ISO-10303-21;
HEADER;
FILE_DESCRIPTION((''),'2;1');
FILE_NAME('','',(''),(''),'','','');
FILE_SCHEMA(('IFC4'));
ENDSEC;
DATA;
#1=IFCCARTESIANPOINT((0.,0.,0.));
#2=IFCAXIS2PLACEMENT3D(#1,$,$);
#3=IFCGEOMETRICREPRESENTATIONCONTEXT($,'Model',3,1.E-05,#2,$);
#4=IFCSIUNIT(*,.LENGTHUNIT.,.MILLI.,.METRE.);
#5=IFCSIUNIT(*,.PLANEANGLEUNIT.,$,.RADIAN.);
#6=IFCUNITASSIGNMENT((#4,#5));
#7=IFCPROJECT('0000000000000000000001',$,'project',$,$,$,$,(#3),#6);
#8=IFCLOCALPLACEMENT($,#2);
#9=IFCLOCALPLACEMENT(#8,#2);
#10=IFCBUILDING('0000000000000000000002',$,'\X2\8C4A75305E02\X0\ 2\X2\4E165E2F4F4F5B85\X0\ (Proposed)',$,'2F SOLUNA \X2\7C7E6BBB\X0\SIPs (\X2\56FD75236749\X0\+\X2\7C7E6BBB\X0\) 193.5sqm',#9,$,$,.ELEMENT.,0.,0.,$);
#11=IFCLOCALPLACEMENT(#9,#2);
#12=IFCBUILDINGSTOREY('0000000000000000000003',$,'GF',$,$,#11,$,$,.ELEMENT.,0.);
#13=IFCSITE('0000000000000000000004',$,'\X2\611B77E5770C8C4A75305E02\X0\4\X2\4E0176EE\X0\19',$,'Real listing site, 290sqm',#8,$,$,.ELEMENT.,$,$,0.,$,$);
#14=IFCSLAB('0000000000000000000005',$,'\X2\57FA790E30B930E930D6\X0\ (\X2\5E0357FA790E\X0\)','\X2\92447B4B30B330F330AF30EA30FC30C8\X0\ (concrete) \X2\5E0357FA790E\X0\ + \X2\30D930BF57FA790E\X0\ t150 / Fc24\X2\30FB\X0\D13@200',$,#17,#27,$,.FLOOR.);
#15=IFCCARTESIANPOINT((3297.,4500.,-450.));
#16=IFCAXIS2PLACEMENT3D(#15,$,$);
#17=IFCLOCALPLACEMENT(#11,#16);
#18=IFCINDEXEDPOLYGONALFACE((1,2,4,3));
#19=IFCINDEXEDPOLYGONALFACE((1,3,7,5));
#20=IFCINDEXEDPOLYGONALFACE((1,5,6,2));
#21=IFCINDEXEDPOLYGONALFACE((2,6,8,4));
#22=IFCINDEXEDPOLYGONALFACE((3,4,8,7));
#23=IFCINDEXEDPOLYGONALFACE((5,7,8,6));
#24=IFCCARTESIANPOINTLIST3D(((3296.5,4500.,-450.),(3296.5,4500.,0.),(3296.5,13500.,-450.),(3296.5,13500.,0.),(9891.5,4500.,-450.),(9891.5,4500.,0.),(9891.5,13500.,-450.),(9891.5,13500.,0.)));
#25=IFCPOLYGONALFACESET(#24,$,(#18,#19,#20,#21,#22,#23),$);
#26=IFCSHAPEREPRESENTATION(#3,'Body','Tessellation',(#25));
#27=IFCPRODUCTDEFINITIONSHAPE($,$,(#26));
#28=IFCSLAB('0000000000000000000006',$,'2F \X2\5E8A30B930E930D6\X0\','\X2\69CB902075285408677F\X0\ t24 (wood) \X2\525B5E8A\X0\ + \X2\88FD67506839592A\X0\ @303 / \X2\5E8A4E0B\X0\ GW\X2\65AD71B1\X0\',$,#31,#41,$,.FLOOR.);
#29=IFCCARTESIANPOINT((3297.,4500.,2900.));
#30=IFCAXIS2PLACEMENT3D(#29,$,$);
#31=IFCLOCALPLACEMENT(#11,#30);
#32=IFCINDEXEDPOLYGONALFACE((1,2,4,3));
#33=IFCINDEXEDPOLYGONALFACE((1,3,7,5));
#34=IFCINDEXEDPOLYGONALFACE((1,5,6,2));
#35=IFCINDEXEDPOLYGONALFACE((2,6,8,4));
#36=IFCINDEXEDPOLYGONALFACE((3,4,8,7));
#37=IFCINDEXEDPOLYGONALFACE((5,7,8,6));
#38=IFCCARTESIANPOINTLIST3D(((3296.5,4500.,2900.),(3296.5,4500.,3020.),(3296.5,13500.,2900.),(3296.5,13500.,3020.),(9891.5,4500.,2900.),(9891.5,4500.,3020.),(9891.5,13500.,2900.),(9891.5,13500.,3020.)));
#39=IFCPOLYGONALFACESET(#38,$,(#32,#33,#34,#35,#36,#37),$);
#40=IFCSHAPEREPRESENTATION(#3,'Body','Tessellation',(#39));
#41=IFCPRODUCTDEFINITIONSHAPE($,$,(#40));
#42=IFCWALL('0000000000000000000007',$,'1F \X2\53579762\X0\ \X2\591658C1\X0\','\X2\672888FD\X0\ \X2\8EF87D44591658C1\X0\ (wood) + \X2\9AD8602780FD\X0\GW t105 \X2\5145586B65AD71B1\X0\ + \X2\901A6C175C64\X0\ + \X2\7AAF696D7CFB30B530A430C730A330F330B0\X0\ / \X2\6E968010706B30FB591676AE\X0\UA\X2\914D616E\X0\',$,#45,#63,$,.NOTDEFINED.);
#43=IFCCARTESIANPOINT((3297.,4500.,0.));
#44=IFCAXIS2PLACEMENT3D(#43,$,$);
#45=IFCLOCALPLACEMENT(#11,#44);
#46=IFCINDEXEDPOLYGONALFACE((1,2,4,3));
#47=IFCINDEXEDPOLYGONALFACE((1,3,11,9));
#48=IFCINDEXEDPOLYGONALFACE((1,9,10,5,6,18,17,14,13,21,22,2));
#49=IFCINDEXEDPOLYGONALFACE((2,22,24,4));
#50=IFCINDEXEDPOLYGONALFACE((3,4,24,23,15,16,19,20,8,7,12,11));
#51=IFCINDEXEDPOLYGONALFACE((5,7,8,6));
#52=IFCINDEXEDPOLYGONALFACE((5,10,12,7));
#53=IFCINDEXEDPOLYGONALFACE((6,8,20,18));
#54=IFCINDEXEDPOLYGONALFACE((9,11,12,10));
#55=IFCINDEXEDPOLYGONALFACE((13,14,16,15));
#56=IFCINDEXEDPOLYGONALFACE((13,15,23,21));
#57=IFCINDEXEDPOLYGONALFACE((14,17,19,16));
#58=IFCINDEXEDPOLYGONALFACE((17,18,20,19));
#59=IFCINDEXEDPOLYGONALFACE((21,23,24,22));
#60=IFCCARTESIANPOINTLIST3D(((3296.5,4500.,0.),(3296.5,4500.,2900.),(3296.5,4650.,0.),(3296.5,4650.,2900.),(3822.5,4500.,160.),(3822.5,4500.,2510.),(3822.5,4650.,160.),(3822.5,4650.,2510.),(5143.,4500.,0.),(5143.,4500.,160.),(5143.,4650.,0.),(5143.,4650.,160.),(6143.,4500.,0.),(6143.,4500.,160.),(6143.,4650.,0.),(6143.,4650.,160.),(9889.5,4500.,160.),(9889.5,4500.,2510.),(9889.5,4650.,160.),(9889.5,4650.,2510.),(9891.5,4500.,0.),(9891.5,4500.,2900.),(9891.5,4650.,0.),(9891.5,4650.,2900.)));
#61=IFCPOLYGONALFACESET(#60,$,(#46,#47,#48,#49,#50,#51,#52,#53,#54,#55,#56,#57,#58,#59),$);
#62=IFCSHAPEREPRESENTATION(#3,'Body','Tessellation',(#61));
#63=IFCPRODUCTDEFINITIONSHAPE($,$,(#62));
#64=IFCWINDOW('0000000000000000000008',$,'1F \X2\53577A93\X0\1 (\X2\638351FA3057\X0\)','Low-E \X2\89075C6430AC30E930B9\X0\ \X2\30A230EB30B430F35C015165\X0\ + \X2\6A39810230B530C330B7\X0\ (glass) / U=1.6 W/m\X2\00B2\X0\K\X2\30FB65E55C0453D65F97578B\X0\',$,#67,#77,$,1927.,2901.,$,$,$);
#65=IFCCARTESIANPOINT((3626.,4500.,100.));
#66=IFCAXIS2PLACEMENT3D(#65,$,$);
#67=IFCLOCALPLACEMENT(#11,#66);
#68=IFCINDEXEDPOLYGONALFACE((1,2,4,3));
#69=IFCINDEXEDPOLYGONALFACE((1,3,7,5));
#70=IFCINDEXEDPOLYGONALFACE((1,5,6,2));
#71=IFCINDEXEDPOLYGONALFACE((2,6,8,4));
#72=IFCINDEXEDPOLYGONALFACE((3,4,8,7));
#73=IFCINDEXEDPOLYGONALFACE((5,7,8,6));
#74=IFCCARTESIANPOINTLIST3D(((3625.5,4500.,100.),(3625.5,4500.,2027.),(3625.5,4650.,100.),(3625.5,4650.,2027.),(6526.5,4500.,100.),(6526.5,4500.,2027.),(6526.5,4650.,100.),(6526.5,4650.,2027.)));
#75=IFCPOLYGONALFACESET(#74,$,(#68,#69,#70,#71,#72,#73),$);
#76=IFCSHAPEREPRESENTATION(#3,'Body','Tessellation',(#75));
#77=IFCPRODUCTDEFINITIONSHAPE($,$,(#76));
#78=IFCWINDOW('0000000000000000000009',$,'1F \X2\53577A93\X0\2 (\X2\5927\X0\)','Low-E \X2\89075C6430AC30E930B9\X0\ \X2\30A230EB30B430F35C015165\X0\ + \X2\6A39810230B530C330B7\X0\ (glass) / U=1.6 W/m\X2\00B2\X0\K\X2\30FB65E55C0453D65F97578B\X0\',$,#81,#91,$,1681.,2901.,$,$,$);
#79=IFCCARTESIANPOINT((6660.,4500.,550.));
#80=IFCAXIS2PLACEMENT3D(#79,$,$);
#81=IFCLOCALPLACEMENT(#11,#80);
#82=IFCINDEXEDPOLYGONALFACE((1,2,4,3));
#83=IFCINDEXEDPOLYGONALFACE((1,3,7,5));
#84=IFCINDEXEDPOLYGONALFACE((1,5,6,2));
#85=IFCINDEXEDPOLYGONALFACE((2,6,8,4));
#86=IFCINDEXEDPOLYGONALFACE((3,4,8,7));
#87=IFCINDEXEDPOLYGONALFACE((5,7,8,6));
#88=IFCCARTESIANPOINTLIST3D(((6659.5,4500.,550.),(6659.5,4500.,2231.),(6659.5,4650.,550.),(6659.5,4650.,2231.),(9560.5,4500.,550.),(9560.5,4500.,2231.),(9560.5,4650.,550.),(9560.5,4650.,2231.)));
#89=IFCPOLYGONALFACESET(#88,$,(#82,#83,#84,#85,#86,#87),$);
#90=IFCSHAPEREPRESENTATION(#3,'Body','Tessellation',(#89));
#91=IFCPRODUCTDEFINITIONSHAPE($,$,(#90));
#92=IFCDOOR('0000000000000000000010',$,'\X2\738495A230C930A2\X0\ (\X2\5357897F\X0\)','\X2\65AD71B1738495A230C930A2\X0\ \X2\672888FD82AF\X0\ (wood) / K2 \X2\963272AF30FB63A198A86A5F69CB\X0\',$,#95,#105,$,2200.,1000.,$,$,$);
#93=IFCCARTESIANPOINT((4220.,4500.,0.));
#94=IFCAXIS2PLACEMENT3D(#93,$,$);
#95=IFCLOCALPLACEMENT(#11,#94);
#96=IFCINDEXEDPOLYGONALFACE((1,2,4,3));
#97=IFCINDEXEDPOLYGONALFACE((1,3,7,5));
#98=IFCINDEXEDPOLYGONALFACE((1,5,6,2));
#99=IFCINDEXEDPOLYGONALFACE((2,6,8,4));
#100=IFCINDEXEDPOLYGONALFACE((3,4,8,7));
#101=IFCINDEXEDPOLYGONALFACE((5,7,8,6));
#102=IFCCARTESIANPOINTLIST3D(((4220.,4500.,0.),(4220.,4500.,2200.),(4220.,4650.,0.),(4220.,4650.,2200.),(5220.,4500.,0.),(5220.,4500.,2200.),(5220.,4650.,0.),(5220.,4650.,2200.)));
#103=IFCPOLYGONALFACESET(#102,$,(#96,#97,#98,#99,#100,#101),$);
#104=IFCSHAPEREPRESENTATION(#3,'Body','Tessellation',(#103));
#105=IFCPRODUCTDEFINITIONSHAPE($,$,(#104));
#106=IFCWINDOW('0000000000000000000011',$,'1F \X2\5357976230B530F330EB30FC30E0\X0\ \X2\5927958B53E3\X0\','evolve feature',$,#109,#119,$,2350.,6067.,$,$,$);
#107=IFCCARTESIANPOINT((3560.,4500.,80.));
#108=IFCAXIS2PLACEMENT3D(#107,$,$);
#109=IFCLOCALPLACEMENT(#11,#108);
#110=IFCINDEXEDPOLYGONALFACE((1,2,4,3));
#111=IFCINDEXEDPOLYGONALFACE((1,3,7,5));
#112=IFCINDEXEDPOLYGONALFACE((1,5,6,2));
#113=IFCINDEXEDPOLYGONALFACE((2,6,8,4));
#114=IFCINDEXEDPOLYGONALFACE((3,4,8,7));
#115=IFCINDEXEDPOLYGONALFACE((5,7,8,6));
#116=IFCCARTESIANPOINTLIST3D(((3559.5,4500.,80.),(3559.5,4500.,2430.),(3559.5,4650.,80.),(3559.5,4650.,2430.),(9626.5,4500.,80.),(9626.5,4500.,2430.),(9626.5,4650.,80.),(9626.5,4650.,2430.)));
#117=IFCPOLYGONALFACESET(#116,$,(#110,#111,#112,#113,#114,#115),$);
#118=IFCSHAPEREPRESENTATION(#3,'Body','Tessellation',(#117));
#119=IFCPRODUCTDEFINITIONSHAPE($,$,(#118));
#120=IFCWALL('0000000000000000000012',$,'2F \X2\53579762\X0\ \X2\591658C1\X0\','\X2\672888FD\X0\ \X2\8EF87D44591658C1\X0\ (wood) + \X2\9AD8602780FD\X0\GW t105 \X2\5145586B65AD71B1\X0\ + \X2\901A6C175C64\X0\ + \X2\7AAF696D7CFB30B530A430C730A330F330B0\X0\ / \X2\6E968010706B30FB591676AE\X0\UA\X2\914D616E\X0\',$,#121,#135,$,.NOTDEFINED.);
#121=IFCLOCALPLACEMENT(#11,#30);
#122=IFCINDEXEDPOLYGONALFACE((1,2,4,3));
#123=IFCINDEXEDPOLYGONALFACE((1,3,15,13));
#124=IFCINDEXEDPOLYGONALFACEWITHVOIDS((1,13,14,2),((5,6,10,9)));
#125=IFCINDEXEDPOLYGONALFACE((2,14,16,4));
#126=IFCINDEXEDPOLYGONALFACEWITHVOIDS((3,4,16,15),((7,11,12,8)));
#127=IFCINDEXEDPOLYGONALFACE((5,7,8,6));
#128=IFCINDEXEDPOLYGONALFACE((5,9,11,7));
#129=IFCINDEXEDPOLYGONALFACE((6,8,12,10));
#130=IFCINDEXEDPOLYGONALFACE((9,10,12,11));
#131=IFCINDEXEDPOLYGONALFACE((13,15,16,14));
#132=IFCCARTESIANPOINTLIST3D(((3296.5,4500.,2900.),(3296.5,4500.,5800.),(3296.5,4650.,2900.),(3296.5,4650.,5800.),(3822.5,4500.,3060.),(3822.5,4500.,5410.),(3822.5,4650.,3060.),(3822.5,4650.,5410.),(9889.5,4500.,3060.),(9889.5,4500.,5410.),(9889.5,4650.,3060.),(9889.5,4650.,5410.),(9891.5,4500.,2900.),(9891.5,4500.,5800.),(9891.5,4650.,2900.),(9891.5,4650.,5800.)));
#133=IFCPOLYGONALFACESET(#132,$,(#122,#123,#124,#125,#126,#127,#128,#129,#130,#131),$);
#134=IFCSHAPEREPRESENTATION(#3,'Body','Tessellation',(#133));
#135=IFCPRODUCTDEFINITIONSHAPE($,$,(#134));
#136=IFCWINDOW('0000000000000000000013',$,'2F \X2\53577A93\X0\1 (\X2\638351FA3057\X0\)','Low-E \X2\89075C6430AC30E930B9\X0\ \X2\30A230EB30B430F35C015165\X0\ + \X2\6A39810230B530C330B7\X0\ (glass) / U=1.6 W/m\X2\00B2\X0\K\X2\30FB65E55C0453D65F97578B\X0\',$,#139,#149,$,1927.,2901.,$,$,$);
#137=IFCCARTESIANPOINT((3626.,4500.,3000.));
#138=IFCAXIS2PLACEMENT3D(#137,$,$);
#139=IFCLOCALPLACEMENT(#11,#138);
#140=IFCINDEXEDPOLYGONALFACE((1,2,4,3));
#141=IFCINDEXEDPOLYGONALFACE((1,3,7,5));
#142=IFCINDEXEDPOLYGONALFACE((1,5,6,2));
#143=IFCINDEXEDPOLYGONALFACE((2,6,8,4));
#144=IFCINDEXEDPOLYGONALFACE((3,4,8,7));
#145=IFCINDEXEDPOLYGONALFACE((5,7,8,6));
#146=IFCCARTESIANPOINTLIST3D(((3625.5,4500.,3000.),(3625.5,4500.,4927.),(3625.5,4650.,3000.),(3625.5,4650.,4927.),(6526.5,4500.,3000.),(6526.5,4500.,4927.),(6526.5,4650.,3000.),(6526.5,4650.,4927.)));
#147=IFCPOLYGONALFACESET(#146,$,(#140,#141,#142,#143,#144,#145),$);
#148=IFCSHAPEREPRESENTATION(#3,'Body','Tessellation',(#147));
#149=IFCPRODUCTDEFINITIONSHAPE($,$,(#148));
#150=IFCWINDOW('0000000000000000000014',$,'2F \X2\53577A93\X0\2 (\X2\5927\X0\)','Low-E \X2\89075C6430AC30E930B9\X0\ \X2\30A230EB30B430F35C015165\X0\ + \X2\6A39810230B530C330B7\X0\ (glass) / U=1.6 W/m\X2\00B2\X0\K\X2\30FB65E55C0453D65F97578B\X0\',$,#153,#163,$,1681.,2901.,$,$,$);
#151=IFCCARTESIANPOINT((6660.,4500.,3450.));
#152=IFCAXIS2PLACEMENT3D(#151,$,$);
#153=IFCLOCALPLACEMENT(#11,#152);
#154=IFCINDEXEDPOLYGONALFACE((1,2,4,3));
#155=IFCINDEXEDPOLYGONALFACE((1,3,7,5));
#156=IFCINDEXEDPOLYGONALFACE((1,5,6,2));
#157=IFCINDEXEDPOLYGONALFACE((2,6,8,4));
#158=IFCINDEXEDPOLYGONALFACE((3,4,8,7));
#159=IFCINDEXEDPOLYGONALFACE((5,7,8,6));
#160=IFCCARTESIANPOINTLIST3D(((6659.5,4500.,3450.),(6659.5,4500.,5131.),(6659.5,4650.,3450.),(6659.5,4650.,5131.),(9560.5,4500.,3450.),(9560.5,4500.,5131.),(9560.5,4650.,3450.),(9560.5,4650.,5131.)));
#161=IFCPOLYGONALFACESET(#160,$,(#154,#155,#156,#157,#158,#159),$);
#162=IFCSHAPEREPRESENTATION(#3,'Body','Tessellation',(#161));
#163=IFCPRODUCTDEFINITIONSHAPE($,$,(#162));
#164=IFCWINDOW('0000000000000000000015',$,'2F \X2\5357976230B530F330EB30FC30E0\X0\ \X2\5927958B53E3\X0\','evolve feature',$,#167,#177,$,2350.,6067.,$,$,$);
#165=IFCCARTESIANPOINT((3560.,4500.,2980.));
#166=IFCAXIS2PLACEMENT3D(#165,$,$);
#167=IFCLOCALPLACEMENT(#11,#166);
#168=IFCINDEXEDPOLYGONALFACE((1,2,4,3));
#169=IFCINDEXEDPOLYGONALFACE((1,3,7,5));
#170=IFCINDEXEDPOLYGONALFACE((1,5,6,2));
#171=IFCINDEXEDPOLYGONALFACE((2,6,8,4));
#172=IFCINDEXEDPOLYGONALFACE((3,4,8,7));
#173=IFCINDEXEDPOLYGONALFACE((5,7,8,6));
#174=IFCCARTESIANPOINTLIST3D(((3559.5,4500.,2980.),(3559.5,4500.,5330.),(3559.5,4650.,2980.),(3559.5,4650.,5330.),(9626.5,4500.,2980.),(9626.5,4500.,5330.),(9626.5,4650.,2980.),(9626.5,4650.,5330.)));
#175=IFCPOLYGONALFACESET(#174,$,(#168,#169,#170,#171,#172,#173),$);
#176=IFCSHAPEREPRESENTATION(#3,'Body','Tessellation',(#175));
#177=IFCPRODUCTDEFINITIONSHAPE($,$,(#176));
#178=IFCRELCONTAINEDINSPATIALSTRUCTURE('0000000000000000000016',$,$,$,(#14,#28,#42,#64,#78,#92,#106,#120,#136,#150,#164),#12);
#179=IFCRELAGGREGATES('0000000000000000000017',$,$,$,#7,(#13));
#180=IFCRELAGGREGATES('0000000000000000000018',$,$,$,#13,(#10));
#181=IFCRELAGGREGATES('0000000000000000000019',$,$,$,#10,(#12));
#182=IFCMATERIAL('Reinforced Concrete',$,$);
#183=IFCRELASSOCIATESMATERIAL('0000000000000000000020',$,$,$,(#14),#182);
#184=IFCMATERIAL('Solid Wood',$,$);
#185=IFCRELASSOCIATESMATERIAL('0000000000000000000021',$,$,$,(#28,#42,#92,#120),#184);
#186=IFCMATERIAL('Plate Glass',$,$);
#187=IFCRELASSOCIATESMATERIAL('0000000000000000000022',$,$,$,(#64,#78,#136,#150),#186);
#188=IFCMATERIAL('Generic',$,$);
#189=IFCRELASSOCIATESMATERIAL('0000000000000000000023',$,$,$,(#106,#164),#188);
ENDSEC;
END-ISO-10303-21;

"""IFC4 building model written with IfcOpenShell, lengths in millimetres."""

from ifc_helpers import new_model, si_unit, frame, frame_2d, origin, place, context, project, spatial, rectangle, extrude, material, element, fill, save


model = new_model("IFC4")

# Units and contexts
model_context = context("Model", 3, precision=1e-05, world=origin())
ifc_project = project(units=[si_unit("LENGTHUNIT", "METRE", prefix="MILLI"), si_unit("PLANEANGLEUNIT", "RADIAN")], contexts=[model_context])

# Site, building, storey
site_placement = place(None, origin())
site = spatial("IfcSite", under=ifc_project, at=site_placement, Name="愛知県豊田市4丁目19", ObjectType="Real listing site, 290sqm", CompositionType="ELEMENT", RefElevation=0.0)
building_placement = place(site_placement, origin())
building = spatial("IfcBuilding", under=site, at=building_placement, Name="豊田市 2世帯住宅 (Proposed)", ObjectType="2F SOLUNA 籾殻SIPs (国産杉+籾殻) 193.5sqm", CompositionType="ELEMENT", ElevationOfRefHeight=0.0, ElevationOfTerrain=0.0)
storey_placement = place(building_placement, origin())
storey = spatial("IfcBuildingStorey", under=building, at=storey_placement, Name="GF", CompositionType="ELEMENT", Elevation=0.0)

# Slabs
ifc_material_1 = material(Name="Reinforced Concrete")
slab_1_placement = place(storey_placement, frame((3297.0, 4500.0, -450.0)))
element("IfcSlab", 1, at=slab_1_placement, inside=storey, material=ifc_material_1, Name="基礎スラブ (布基礎)", Description="鉄筋コンクリート (concrete) 布基礎 + ベタ基礎 t150 / Fc24・D13@200", PredefinedType="FLOOR", context=model_context, shape_type="SweptSolid", body=[
    extrude(rectangle(XDim=6595.0, YDim=9000.0, at=frame_2d((3297.0, 4500.0))), frame((3297.0, 4500.0, -450.0)), (0.0, 0.0, 1.0), 450.0),
])
ifc_material_2 = material(Name="Solid Wood")
slab_2_placement = place(storey_placement, frame((3297.0, 4500.0, 2900.0)))
element("IfcSlab", 2, at=slab_2_placement, inside=storey, material=ifc_material_2, Name="2F 床スラブ", Description="構造用合板 t24 (wood) 剛床 + 製材根太 @303 / 床下 GW断熱", PredefinedType="FLOOR", context=model_context, shape_type="SweptSolid", body=[
    extrude(rectangle(XDim=6595.0, YDim=9000.0, at=frame_2d((3297.0, 4500.0))), frame((3297.0, 4500.0, 2900.0)), (0.0, 0.0, 1.0), 120.0),
])

# Wall, openings, windows, door
wall_1_placement = place(storey_placement, frame((3297.0, 4500.0, 0.0)))
wall_1 = element("IfcWall", 3, at=wall_1_placement, inside=storey, material=ifc_material_2, Name="1F 南面 外壁", Description="木製 軸組外壁 (wood) + 高性能GW t105 充填断熱 + 通気層 + 窯業系サイディング / 準耐火・外皮UA配慮", PredefinedType="NOTDEFINED", context=model_context, shape_type="SweptSolid", body=[
    extrude(rectangle(XDim=6595.0, YDim=150.0, at=frame_2d((3297.0, 75.0))), frame((3297.0, 4500.0, 0.0)), (0.0, 0.0, 1.0), 2900.0),
])
opening_1_placement = place(storey_placement, frame((3626.0, 4500.0, 100.0)))
opening_1 = element("IfcOpeningElement", 4, at=opening_1_placement, cuts=wall_1, PredefinedType="NOTDEFINED", context=model_context, shape_type="SweptSolid", body=[
    extrude(rectangle(XDim=2901.0, YDim=150.0, at=frame_2d((1450.0, 75.0))), frame((3626.0, 4500.0, 100.0)), (0.0, 0.0, 1.0), 1927.0),
])
opening_2_placement = place(storey_placement, frame((6660.0, 4500.0, 550.0)))
opening_2 = element("IfcOpeningElement", 5, at=opening_2_placement, cuts=wall_1, PredefinedType="NOTDEFINED", context=model_context, shape_type="SweptSolid", body=[
    extrude(rectangle(XDim=2901.0, YDim=150.0, at=frame_2d((1450.0, 75.0))), frame((6660.0, 4500.0, 550.0)), (0.0, 0.0, 1.0), 1681.0),
])
opening_3_placement = place(storey_placement, frame((4220.0, 4500.0, 0.0)))
opening_3 = element("IfcOpeningElement", 6, at=opening_3_placement, cuts=wall_1, PredefinedType="NOTDEFINED", context=model_context, shape_type="SweptSolid", body=[
    extrude(rectangle(XDim=1000.0, YDim=150.0, at=frame_2d((500.0, 75.0))), frame((4220.0, 4500.0, 0.0)), (0.0, 0.0, 1.0), 2200.0),
])
opening_4_placement = place(storey_placement, frame((3560.0, 4500.0, 80.0)))
opening_4 = element("IfcOpeningElement", 7, at=opening_4_placement, cuts=wall_1, PredefinedType="NOTDEFINED", context=model_context, shape_type="SweptSolid", body=[
    extrude(rectangle(XDim=6067.0, YDim=150.0, at=frame_2d((3033.0, 75.0))), frame((3560.0, 4500.0, 80.0)), (0.0, 0.0, 1.0), 2350.0),
])
ifc_material_3 = material(Name="Plate Glass")
window_1_placement = place(storey_placement, frame((3626.0, 4500.0, 100.0)))
window_1 = element("IfcWindow", 8, at=window_1_placement, inside=storey, material=ifc_material_3, Name="1F 南窓1 (掃出し)", Description="Low-E 複層ガラス アルゴン封入 + 樹脂サッシ (glass) / U=1.6 W/m²K・日射取得型", OverallHeight=1927.0, OverallWidth=2901.0, context=model_context, shape_type="SweptSolid", body=[
    extrude(rectangle(XDim=2901.0, YDim=150.0, at=frame_2d((1450.0, 75.0))), frame((3626.0, 4500.0, 100.0)), (0.0, 0.0, 1.0), 1927.0),
])
fill(opening_1, window_1)
window_2_placement = place(storey_placement, frame((6660.0, 4500.0, 550.0)))
window_2 = element("IfcWindow", 9, at=window_2_placement, inside=storey, material=ifc_material_3, Name="1F 南窓2 (大)", Description="Low-E 複層ガラス アルゴン封入 + 樹脂サッシ (glass) / U=1.6 W/m²K・日射取得型", OverallHeight=1681.0, OverallWidth=2901.0, context=model_context, shape_type="SweptSolid", body=[
    extrude(rectangle(XDim=2901.0, YDim=150.0, at=frame_2d((1450.0, 75.0))), frame((6660.0, 4500.0, 550.0)), (0.0, 0.0, 1.0), 1681.0),
])
fill(opening_2, window_2)
door_placement = place(storey_placement, frame((4220.0, 4500.0, 0.0)))
door = element("IfcDoor", 10, at=door_placement, inside=storey, material=ifc_material_2, Name="玄関ドア (南西)", Description="断熱玄関ドア 木製芯 (wood) / K2 防犯・採風機構", OverallHeight=2200.0, OverallWidth=1000.0, context=model_context, shape_type="SweptSolid", body=[
    extrude(rectangle(XDim=1000.0, YDim=150.0, at=frame_2d((500.0, 75.0))), frame((4220.0, 4500.0, 0.0)), (0.0, 0.0, 1.0), 2200.0),
])
fill(opening_3, door)
ifc_material_4 = material(Name="Generic")
window_3_placement = place(storey_placement, frame((3560.0, 4500.0, 80.0)))
window_3 = element("IfcWindow", 11, at=window_3_placement, inside=storey, material=ifc_material_4, Name="1F 南面サンルーム 大開口", Description="evolve feature", OverallHeight=2350.0, OverallWidth=6067.0, context=model_context, shape_type="SweptSolid", body=[
    extrude(rectangle(XDim=6067.0, YDim=150.0, at=frame_2d((3033.0, 75.0))), frame((3560.0, 4500.0, 80.0)), (0.0, 0.0, 1.0), 2350.0),
])
fill(opening_4, window_3)

# Wall, openings, windows
wall_2_placement = place(storey_placement, frame((3297.0, 4500.0, 2900.0)))
wall_2 = element("IfcWall", 12, at=wall_2_placement, inside=storey, material=ifc_material_2, Name="2F 南面 外壁", Description="木製 軸組外壁 (wood) + 高性能GW t105 充填断熱 + 通気層 + 窯業系サイディング / 準耐火・外皮UA配慮", PredefinedType="NOTDEFINED", context=model_context, shape_type="SweptSolid", body=[
    extrude(rectangle(XDim=6595.0, YDim=150.0, at=frame_2d((3297.0, 75.0))), frame((3297.0, 4500.0, 2900.0)), (0.0, 0.0, 1.0), 2900.0),
])
opening_5_placement = place(storey_placement, frame((3626.0, 4500.0, 3000.0)))
opening_5 = element("IfcOpeningElement", 13, at=opening_5_placement, cuts=wall_2, PredefinedType="NOTDEFINED", context=model_context, shape_type="SweptSolid", body=[
    extrude(rectangle(XDim=2901.0, YDim=150.0, at=frame_2d((1450.0, 75.0))), frame((3626.0, 4500.0, 3000.0)), (0.0, 0.0, 1.0), 1927.0),
])
opening_6_placement = place(storey_placement, frame((6660.0, 4500.0, 3450.0)))
opening_6 = element("IfcOpeningElement", 14, at=opening_6_placement, cuts=wall_2, PredefinedType="NOTDEFINED", context=model_context, shape_type="SweptSolid", body=[
    extrude(rectangle(XDim=2901.0, YDim=150.0, at=frame_2d((1450.0, 75.0))), frame((6660.0, 4500.0, 3450.0)), (0.0, 0.0, 1.0), 1681.0),
])
opening_7_placement = place(storey_placement, frame((3560.0, 4500.0, 2980.0)))
opening_7 = element("IfcOpeningElement", 15, at=opening_7_placement, cuts=wall_2, PredefinedType="NOTDEFINED", context=model_context, shape_type="SweptSolid", body=[
    extrude(rectangle(XDim=6067.0, YDim=150.0, at=frame_2d((3033.0, 75.0))), frame((3560.0, 4500.0, 2980.0)), (0.0, 0.0, 1.0), 2350.0),
])
window_4_placement = place(storey_placement, frame((3626.0, 4500.0, 3000.0)))
window_4 = element("IfcWindow", 16, at=window_4_placement, inside=storey, material=ifc_material_3, Name="2F 南窓1 (掃出し)", Description="Low-E 複層ガラス アルゴン封入 + 樹脂サッシ (glass) / U=1.6 W/m²K・日射取得型", OverallHeight=1927.0, OverallWidth=2901.0, context=model_context, shape_type="SweptSolid", body=[
    extrude(rectangle(XDim=2901.0, YDim=150.0, at=frame_2d((1450.0, 75.0))), frame((3626.0, 4500.0, 3000.0)), (0.0, 0.0, 1.0), 1927.0),
])
fill(opening_5, window_4)
window_5_placement = place(storey_placement, frame((6660.0, 4500.0, 3450.0)))
window_5 = element("IfcWindow", 17, at=window_5_placement, inside=storey, material=ifc_material_3, Name="2F 南窓2 (大)", Description="Low-E 複層ガラス アルゴン封入 + 樹脂サッシ (glass) / U=1.6 W/m²K・日射取得型", OverallHeight=1681.0, OverallWidth=2901.0, context=model_context, shape_type="SweptSolid", body=[
    extrude(rectangle(XDim=2901.0, YDim=150.0, at=frame_2d((1450.0, 75.0))), frame((6660.0, 4500.0, 3450.0)), (0.0, 0.0, 1.0), 1681.0),
])
fill(opening_6, window_5)
window_6_placement = place(storey_placement, frame((3560.0, 4500.0, 2980.0)))
window_6 = element("IfcWindow", 18, at=window_6_placement, inside=storey, material=ifc_material_4, Name="2F 南面サンルーム 大開口", Description="evolve feature", OverallHeight=2350.0, OverallWidth=6067.0, context=model_context, shape_type="SweptSolid", body=[
    extrude(rectangle(XDim=6067.0, YDim=150.0, at=frame_2d((3033.0, 75.0))), frame((3560.0, 4500.0, 2980.0)), (0.0, 0.0, 1.0), 2350.0),
])
fill(opening_7, window_6)

save(model, "model.ifc")
